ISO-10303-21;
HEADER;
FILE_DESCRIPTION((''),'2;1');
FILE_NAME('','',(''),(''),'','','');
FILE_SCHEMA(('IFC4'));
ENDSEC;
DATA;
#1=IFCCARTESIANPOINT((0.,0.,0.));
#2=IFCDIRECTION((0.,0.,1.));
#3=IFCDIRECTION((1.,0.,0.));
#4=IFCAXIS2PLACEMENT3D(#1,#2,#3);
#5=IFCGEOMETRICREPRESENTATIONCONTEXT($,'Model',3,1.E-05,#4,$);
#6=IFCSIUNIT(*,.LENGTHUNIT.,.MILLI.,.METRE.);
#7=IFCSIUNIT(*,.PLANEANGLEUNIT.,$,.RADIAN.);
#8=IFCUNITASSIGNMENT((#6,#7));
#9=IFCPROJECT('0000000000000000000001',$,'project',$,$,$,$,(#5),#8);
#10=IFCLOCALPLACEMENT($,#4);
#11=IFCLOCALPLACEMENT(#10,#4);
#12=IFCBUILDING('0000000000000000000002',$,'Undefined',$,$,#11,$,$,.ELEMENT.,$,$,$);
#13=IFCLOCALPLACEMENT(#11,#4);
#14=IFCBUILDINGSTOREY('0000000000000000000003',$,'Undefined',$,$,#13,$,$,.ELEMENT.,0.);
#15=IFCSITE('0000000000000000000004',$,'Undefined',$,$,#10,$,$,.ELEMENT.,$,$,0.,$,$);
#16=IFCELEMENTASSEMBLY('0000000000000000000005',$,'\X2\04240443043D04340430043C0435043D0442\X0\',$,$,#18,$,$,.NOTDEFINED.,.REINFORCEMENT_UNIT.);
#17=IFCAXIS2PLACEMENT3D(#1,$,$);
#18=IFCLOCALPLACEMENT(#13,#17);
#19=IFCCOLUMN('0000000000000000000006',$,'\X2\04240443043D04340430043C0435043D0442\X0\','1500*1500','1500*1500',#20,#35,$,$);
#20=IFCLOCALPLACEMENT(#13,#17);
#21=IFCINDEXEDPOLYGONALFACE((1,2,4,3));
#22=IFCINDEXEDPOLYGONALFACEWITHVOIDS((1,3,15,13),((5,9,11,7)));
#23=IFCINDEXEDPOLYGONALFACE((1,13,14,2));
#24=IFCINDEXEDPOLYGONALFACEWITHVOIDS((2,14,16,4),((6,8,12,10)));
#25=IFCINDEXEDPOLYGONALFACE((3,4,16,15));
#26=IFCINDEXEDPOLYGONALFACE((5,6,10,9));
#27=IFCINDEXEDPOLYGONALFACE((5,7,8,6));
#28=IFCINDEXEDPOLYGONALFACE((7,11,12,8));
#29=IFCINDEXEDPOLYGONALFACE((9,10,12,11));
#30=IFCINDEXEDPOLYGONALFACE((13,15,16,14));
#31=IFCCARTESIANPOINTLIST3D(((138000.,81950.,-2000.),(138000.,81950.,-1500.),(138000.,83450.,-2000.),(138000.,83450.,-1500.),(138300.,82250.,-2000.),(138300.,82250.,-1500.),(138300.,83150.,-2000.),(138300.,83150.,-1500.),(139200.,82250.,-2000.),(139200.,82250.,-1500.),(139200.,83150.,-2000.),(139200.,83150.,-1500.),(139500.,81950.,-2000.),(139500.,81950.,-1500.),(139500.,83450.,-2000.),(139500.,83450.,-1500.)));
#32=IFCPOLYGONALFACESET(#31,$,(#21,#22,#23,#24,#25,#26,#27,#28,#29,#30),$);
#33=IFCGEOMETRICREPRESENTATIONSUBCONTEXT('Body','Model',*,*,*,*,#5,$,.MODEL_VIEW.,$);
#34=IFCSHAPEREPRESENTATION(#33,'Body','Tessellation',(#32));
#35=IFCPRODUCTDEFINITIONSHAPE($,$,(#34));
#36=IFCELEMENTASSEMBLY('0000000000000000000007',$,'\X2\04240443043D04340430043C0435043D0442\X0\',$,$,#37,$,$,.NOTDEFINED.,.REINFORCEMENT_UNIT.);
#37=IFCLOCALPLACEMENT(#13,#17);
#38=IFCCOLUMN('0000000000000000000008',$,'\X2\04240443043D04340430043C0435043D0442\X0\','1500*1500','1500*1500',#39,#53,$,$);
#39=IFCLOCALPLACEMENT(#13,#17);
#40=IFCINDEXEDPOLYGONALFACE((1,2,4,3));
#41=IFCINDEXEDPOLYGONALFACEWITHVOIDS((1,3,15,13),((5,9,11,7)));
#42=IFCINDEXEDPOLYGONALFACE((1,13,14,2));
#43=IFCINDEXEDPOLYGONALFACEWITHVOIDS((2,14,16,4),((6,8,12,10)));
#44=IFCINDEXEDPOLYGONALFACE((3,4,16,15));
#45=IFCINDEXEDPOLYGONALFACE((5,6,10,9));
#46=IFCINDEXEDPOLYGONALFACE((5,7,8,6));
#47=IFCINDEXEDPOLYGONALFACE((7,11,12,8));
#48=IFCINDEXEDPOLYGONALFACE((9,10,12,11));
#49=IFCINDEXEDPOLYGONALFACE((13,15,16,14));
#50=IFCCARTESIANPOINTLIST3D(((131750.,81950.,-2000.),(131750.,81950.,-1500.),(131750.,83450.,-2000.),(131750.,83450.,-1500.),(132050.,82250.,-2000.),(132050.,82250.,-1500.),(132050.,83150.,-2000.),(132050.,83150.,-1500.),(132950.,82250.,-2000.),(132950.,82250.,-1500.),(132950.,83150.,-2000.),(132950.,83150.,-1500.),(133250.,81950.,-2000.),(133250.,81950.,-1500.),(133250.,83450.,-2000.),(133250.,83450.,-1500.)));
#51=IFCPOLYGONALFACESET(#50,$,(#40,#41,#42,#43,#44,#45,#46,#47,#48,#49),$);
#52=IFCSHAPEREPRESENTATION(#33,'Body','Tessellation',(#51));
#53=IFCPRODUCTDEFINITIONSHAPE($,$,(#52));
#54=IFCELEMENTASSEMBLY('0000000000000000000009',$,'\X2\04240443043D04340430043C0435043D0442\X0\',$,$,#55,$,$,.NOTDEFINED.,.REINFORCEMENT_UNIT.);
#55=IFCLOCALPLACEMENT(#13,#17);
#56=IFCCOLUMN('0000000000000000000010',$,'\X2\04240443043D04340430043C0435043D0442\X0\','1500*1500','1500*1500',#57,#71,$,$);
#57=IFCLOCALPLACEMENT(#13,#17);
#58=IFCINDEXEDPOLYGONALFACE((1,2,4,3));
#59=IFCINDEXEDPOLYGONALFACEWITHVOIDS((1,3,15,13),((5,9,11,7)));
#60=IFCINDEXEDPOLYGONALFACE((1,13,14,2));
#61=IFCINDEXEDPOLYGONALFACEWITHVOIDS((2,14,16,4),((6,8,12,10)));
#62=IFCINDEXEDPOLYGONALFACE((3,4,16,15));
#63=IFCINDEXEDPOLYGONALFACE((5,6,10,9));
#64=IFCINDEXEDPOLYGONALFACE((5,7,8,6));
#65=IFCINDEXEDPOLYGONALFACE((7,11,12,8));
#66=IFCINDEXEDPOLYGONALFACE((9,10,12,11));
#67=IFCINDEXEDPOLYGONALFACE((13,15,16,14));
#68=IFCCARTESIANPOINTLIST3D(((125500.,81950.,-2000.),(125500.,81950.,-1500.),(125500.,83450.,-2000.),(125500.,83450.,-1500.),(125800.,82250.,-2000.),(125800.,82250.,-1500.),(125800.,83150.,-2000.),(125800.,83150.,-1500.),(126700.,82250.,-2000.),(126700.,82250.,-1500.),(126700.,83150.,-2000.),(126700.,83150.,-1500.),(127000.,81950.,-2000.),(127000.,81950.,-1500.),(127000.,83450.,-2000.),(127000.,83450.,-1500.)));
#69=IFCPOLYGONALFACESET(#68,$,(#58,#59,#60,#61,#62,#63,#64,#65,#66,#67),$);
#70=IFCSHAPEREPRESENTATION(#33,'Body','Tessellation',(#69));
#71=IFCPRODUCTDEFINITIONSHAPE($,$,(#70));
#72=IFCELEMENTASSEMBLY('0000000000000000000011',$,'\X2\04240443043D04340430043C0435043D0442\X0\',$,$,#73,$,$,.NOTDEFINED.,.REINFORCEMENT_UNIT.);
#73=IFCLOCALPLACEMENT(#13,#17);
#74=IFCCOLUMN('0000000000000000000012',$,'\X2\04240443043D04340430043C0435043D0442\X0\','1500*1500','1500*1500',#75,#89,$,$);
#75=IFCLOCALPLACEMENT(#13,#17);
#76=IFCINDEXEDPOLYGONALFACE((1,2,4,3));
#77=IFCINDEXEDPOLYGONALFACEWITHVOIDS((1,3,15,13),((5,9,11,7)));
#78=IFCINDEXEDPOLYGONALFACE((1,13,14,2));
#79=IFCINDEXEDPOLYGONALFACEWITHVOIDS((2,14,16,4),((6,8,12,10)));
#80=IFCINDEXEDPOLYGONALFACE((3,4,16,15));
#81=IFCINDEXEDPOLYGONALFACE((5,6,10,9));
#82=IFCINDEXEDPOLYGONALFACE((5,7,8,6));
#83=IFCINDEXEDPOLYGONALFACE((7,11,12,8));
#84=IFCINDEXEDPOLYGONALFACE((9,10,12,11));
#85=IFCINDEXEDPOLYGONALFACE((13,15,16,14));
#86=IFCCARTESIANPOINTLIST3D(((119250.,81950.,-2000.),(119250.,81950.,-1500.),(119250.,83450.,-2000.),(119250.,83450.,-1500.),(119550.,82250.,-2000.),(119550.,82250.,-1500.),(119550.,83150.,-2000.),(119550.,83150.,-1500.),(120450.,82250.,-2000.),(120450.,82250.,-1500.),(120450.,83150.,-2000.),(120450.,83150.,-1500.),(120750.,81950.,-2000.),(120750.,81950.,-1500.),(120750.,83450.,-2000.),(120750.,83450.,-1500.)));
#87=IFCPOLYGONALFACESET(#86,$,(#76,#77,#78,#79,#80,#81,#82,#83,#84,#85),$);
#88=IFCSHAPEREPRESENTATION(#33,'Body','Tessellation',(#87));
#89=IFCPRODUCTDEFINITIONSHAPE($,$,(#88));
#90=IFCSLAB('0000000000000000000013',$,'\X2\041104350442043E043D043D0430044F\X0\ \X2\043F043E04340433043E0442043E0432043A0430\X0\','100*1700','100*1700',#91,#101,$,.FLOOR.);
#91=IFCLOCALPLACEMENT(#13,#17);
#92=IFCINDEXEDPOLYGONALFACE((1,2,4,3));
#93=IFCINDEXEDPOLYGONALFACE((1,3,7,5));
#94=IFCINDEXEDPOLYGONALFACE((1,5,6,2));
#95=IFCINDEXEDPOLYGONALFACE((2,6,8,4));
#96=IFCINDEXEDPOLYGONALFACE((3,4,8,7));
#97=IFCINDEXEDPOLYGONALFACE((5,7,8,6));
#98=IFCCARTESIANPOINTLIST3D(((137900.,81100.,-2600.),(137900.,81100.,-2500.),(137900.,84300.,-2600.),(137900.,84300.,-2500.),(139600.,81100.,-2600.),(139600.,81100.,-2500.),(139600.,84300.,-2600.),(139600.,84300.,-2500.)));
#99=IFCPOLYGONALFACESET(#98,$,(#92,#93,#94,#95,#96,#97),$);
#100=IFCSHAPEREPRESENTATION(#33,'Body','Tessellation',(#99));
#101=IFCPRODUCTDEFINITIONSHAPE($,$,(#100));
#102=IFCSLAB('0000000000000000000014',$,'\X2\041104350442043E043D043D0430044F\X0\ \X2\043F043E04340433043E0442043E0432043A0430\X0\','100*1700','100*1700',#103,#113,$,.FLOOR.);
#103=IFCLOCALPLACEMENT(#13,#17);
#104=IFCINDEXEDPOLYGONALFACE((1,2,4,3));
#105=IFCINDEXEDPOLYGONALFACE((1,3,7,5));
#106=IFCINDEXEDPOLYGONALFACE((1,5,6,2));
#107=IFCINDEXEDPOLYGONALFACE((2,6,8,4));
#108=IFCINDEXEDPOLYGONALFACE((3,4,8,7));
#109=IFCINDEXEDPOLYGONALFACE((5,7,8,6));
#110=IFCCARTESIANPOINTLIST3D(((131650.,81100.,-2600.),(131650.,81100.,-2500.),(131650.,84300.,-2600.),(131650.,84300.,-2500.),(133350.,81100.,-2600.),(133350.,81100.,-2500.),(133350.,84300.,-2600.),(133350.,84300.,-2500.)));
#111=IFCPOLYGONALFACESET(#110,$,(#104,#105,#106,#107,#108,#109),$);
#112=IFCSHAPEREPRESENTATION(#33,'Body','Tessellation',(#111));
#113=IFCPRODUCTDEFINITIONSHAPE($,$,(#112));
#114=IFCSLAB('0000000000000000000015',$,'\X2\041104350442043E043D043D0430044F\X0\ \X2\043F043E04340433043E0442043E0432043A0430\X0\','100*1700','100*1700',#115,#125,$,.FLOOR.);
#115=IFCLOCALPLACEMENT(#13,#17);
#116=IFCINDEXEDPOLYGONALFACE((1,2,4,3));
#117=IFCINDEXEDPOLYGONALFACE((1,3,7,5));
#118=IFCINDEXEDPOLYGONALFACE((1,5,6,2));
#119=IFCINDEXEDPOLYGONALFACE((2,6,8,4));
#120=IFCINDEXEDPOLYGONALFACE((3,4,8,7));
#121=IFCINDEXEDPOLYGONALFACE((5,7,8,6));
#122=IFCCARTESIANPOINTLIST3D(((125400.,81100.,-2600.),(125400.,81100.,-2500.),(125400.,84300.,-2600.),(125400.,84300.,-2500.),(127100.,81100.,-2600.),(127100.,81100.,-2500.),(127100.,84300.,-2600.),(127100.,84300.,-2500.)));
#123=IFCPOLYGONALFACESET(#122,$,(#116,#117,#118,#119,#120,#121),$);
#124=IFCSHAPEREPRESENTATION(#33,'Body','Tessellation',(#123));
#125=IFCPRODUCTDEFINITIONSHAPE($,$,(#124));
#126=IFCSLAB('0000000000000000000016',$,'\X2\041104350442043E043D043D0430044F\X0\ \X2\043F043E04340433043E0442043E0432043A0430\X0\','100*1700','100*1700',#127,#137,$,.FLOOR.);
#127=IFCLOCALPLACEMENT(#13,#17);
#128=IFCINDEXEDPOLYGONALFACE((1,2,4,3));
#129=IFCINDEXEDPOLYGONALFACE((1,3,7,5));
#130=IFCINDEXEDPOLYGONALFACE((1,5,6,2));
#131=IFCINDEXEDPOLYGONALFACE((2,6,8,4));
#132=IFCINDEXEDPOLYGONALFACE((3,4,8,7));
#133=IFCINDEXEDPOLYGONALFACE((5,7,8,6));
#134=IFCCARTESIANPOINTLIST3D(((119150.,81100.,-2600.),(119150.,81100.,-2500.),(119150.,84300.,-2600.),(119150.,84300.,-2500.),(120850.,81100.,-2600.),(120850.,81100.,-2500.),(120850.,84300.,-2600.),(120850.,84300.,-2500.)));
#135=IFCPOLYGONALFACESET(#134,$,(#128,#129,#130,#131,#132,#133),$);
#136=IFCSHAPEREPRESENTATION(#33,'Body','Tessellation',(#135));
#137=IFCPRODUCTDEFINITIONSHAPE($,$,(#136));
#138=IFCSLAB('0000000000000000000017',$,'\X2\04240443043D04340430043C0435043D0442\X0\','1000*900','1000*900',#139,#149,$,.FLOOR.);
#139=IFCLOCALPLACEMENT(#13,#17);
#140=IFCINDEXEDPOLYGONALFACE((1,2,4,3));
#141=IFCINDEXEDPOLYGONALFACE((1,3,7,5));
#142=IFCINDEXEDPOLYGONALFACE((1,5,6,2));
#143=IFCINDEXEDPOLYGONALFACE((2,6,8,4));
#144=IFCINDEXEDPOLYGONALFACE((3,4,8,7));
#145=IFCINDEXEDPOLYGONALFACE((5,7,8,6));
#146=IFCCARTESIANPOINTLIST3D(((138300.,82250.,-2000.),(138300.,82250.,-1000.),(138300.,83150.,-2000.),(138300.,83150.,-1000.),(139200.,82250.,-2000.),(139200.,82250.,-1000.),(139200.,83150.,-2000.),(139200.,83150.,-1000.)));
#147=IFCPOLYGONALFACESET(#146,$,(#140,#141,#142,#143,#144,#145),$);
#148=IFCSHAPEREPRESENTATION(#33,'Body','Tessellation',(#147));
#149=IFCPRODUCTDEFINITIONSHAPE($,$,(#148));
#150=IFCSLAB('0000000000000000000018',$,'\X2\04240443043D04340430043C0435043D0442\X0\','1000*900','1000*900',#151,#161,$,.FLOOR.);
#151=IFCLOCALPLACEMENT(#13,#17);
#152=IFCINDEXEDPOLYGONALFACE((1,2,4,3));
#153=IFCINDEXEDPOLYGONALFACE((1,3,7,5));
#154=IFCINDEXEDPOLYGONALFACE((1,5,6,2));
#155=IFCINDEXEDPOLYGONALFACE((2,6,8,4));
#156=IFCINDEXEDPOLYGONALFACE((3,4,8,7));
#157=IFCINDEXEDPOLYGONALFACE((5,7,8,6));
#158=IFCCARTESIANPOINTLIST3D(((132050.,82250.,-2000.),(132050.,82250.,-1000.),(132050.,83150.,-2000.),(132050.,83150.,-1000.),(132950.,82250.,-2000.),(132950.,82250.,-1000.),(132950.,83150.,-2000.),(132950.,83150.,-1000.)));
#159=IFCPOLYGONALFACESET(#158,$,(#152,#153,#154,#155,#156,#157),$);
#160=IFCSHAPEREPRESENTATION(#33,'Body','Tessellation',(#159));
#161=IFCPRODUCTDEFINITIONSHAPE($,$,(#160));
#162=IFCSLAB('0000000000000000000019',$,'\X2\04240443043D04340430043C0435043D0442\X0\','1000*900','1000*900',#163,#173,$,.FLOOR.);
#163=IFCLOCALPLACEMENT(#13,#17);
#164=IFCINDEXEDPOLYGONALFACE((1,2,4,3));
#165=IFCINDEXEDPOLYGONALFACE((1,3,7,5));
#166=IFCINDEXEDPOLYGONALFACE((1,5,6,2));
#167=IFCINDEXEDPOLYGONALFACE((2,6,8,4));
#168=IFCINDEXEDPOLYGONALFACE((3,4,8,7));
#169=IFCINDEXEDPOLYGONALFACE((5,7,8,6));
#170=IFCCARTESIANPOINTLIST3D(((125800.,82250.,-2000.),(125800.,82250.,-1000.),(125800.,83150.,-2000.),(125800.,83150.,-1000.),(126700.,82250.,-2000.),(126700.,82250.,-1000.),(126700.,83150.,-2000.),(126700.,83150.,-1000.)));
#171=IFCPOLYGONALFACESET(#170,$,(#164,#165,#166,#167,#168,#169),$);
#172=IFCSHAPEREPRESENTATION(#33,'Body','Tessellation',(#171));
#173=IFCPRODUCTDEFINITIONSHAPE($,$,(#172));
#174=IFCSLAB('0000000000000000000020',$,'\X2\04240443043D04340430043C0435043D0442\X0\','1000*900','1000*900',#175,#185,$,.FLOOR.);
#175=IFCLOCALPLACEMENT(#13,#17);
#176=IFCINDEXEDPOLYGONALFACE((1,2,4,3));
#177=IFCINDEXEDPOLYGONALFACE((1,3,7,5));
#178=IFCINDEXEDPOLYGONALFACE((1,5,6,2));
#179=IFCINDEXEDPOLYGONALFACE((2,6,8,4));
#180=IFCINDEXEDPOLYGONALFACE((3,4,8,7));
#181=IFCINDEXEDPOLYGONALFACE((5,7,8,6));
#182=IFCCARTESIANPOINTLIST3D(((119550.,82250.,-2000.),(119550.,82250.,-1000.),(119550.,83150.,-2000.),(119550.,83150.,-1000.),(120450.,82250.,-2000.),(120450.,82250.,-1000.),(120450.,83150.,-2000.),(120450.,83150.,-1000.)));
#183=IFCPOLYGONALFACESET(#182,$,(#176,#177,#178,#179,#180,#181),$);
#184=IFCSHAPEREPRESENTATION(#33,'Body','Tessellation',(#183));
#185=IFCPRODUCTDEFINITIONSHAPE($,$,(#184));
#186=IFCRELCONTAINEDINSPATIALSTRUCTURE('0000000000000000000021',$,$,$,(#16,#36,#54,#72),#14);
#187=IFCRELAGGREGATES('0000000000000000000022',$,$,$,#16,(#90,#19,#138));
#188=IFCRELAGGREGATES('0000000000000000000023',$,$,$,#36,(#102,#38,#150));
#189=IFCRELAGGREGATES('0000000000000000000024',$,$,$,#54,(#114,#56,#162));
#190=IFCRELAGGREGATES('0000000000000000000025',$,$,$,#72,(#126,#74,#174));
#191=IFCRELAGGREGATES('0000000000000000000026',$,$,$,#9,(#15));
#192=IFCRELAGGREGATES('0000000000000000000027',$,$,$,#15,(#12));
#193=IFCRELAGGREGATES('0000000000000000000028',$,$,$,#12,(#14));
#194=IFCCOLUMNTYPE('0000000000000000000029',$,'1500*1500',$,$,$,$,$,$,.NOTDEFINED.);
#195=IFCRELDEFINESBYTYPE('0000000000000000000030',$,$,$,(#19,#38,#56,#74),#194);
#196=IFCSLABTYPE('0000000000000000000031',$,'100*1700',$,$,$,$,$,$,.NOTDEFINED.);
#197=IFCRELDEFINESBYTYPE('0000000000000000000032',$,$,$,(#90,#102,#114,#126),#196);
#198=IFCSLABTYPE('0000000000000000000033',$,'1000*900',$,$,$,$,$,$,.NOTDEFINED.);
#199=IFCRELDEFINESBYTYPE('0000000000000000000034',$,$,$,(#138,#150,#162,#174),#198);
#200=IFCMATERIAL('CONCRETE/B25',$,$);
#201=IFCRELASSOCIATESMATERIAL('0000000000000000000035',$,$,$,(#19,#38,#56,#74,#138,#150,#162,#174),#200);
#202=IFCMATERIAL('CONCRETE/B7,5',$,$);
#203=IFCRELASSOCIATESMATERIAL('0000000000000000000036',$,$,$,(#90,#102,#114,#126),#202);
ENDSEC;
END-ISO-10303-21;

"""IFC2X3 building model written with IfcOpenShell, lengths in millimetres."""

from ifc_helpers import new_model, si_unit, frame, origin_with_axes, origin_2d_with_axis, place, context, subcontext, project, spatial, polyline, rectangle, outline, extrude, boolean, material, type_object, element, aggregate, save


model = new_model("IFC2X3")

# Units and contexts
model_context = context("Model", 3, precision=1e-05, world=origin_with_axes())
body_context = subcontext(model_context, "Body", "Model", "MODEL_VIEW")
ifc_project = project(units=[si_unit("LENGTHUNIT", "METRE", prefix="MILLI"), si_unit("PLANEANGLEUNIT", "RADIAN")], contexts=[model_context])

# Site, building, storey
site_placement = place(None, origin_with_axes())
site = spatial("IfcSite", under=ifc_project, at=site_placement, Name="Undefined", CompositionType="ELEMENT", RefElevation=0.0)
building_placement = place(site_placement, origin_with_axes())
building = spatial("IfcBuilding", under=site, at=building_placement, Name="Undefined", CompositionType="ELEMENT")
storey_placement = place(building_placement, origin_with_axes())
storey = spatial("IfcBuildingStorey", under=building, at=storey_placement, Name="Undefined", CompositionType="ELEMENT", Elevation=0.0)

# Element assemblies, columns
assembly_1_placement = place(storey_placement, origin_with_axes())
assembly_1 = element("IfcElementAssembly", 1, at=assembly_1_placement, inside=storey, Name="Фундамент", AssemblyPlace="NOTDEFINED", PredefinedType="REINFORCEMENT_UNIT")
ifc_material_1 = material(Name="CONCRETE/B25")
column_type = type_object("IfcColumnType", Name="1500*1500", PredefinedType="NOTDEFINED")
column_1_placement = place(assembly_1_placement, frame((138750.0, 82700.0, -2000.0), z_axis=(0.0, 0.0, 1.0), x_axis=(0.0, -1.0, 0.0)))
column_1 = element("IfcColumn", 2, at=column_1_placement, type_object=column_type, material=ifc_material_1, Name="Фундамент", Description="1500*1500", ObjectType="1500*1500", context=body_context, shape_type="CSG", body=[
    boolean("DIFFERENCE", extrude(rectangle(XDim=1500.0, YDim=1500.0, at=origin_2d_with_axis()), frame((0.0, 0.0, 500.0), z_axis=(0.0, 0.0, -1.0), x_axis=(0.0, 1.0, 0.0)), (0.0, 0.0, 1.0), 500.0), extrude(outline(polyline([(0.0, 0.0), (900.0, 0.0), (900.0, 900.0), (0.0, 900.0), (0.0, 0.0)])), frame((-450.0, -450.0, -100.0), z_axis=(0.0, 0.0, 1.0), x_axis=(1.0, 0.0, 0.0)), (0.0, 0.0, 1.0), 700.0)),
])
assembly_2_placement = place(storey_placement, origin_with_axes())
assembly_2 = element("IfcElementAssembly", 3, at=assembly_2_placement, inside=storey, Name="Фундамент", AssemblyPlace="NOTDEFINED", PredefinedType="REINFORCEMENT_UNIT")
column_2_placement = place(assembly_2_placement, frame((132500.0, 82700.0, -2000.0), z_axis=(0.0, 0.0, 1.0), x_axis=(0.0, -1.0, 0.0)))
column_2 = element("IfcColumn", 4, at=column_2_placement, type_object=column_type, material=ifc_material_1, Name="Фундамент", Description="1500*1500", ObjectType="1500*1500", context=body_context, shape_type="CSG", body=[
    boolean("DIFFERENCE", extrude(rectangle(XDim=1500.0, YDim=1500.0, at=origin_2d_with_axis()), frame((0.0, 0.0, 500.0), z_axis=(0.0, 0.0, -1.0), x_axis=(0.0, 1.0, 0.0)), (0.0, 0.0, 1.0), 500.0), extrude(outline(polyline([(0.0, 0.0), (900.0, 0.0), (900.0, 900.0), (0.0, 900.0), (0.0, 0.0)])), frame((-450.0, -450.0, -100.0), z_axis=(0.0, 0.0, 1.0), x_axis=(1.0, 0.0, 0.0)), (0.0, 0.0, 1.0), 700.0)),
])
assembly_3_placement = place(storey_placement, origin_with_axes())
assembly_3 = element("IfcElementAssembly", 5, at=assembly_3_placement, inside=storey, Name="Фундамент", AssemblyPlace="NOTDEFINED", PredefinedType="REINFORCEMENT_UNIT")
column_3_placement = place(assembly_3_placement, frame((126250.0, 82700.0, -2000.0), z_axis=(0.0, 0.0, 1.0), x_axis=(0.0, -1.0, 0.0)))
column_3 = element("IfcColumn", 6, at=column_3_placement, type_object=column_type, material=ifc_material_1, Name="Фундамент", Description="1500*1500", ObjectType="1500*1500", context=body_context, shape_type="CSG", body=[
    boolean("DIFFERENCE", extrude(rectangle(XDim=1500.0, YDim=1500.0, at=origin_2d_with_axis()), frame((0.0, 0.0, 500.0), z_axis=(0.0, 0.0, -1.0), x_axis=(0.0, 1.0, 0.0)), (0.0, 0.0, 1.0), 500.0), extrude(outline(polyline([(0.0, 0.0), (900.0, 0.0), (900.0, 900.0), (0.0, 900.0), (0.0, 0.0)])), frame((-450.0, -450.0, -100.0), z_axis=(0.0, 0.0, 1.0), x_axis=(1.0, 0.0, 0.0)), (0.0, 0.0, 1.0), 700.0)),
])
assembly_4_placement = place(storey_placement, origin_with_axes())
assembly_4 = element("IfcElementAssembly", 7, at=assembly_4_placement, inside=storey, Name="Фундамент", AssemblyPlace="NOTDEFINED", PredefinedType="REINFORCEMENT_UNIT")
column_4_placement = place(assembly_4_placement, frame((120000.0, 82700.0, -2000.0), z_axis=(0.0, 0.0, 1.0), x_axis=(0.0, -1.0, 0.0)))
column_4 = element("IfcColumn", 8, at=column_4_placement, type_object=column_type, material=ifc_material_1, Name="Фундамент", Description="1500*1500", ObjectType="1500*1500", context=body_context, shape_type="CSG", body=[
    boolean("DIFFERENCE", extrude(rectangle(XDim=1500.0, YDim=1500.0, at=origin_2d_with_axis()), frame((0.0, 0.0, 500.0), z_axis=(0.0, 0.0, -1.0), x_axis=(0.0, 1.0, 0.0)), (0.0, 0.0, 1.0), 500.0), extrude(outline(polyline([(0.0, 0.0), (900.0, 0.0), (900.0, 900.0), (0.0, 900.0), (0.0, 0.0)])), frame((-450.0, -450.0, -100.0), z_axis=(0.0, 0.0, 1.0), x_axis=(1.0, 0.0, 0.0)), (0.0, 0.0, 1.0), 700.0)),
])

# Slabs
ifc_material_2 = material(Name="CONCRETE/B7,5")
slab_type_1 = type_object("IfcSlabType", Name="100*1700", PredefinedType="NOTDEFINED")
slab_1_placement = place(assembly_1_placement, frame((137900.0, 84300.0, -2550.0), z_axis=(0.0, 0.0, 1.0), x_axis=(0.0, -1.0, 0.0)))
slab_1 = element("IfcSlab", 9, at=slab_1_placement, type_object=slab_type_1, material=ifc_material_2, Name="Бетонная подготовка", Description="100*1700", ObjectType="100*1700", PredefinedType="FLOOR", context=body_context, shape_type="SweptSolid", body=[
    extrude(outline(polyline([(0.0, 0.0), (3200.0, 0.0), (3200.0, 1700.0), (0.0, 1700.0), (0.0, 0.0)])), frame((0.0, 0.0, -50.0), z_axis=(0.0, 0.0, 1.0), x_axis=(1.0, 0.0, 0.0)), (0.0, 0.0, 1.0), 100.0),
])
slab_2_placement = place(assembly_2_placement, frame((131650.0, 84300.0, -2550.0), z_axis=(0.0, 0.0, 1.0), x_axis=(0.0, -1.0, 0.0)))
slab_2 = element("IfcSlab", 10, at=slab_2_placement, type_object=slab_type_1, material=ifc_material_2, Name="Бетонная подготовка", Description="100*1700", ObjectType="100*1700", PredefinedType="FLOOR", context=body_context, shape_type="SweptSolid", body=[
    extrude(outline(polyline([(0.0, 0.0), (3200.0, 0.0), (3200.0, 1700.0), (0.0, 1700.0), (0.0, 0.0)])), frame((0.0, 0.0, -50.0), z_axis=(0.0, 0.0, 1.0), x_axis=(1.0, 0.0, 0.0)), (0.0, 0.0, 1.0), 100.0),
])
slab_3_placement = place(assembly_3_placement, frame((125400.0, 84300.0, -2550.0), z_axis=(0.0, 0.0, 1.0), x_axis=(0.0, -1.0, 0.0)))
slab_3 = element("IfcSlab", 11, at=slab_3_placement, type_object=slab_type_1, material=ifc_material_2, Name="Бетонная подготовка", Description="100*1700", ObjectType="100*1700", PredefinedType="FLOOR", context=body_context, shape_type="SweptSolid", body=[
    extrude(outline(polyline([(0.0, 0.0), (3200.0, 0.0), (3200.0, 1700.0), (0.0, 1700.0), (0.0, 0.0)])), frame((0.0, 0.0, -50.0), z_axis=(0.0, 0.0, 1.0), x_axis=(1.0, 0.0, 0.0)), (0.0, 0.0, 1.0), 100.0),
])
slab_4_placement = place(assembly_4_placement, frame((119150.0, 84300.0, -2550.0), z_axis=(0.0, 0.0, 1.0), x_axis=(0.0, -1.0, 0.0)))
slab_4 = element("IfcSlab", 12, at=slab_4_placement, type_object=slab_type_1, material=ifc_material_2, Name="Бетонная подготовка", Description="100*1700", ObjectType="100*1700", PredefinedType="FLOOR", context=body_context, shape_type="SweptSolid", body=[
    extrude(outline(polyline([(0.0, 0.0), (3200.0, 0.0), (3200.0, 1700.0), (0.0, 1700.0), (0.0, 0.0)])), frame((0.0, 0.0, -50.0), z_axis=(0.0, 0.0, 1.0), x_axis=(1.0, 0.0, 0.0)), (0.0, 0.0, 1.0), 100.0),
])
slab_type_2 = type_object("IfcSlabType", Name="1000*900", PredefinedType="NOTDEFINED")
slab_5_placement = place(assembly_1_placement, frame((138300.0, 83150.0, -1500.0), z_axis=(0.0, 0.0, 1.0), x_axis=(0.0, -1.0, 0.0)))
slab_5 = element("IfcSlab", 13, at=slab_5_placement, type_object=slab_type_2, material=ifc_material_1, Name="Фундамент", Description="1000*900", ObjectType="1000*900", PredefinedType="FLOOR", context=body_context, shape_type="SweptSolid", body=[
    extrude(outline(polyline([(0.0, 0.0), (900.0, 0.0), (900.0, 900.0), (0.0, 900.0), (0.0, 0.0)])), frame((0.0, 0.0, -500.0), z_axis=(0.0, 0.0, 1.0), x_axis=(1.0, 0.0, 0.0)), (0.0, 0.0, 1.0), 1000.0),
])
slab_6_placement = place(assembly_2_placement, frame((132050.0, 83150.0, -1500.0), z_axis=(0.0, 0.0, 1.0), x_axis=(0.0, -1.0, 0.0)))
slab_6 = element("IfcSlab", 14, at=slab_6_placement, type_object=slab_type_2, material=ifc_material_1, Name="Фундамент", Description="1000*900", ObjectType="1000*900", PredefinedType="FLOOR", context=body_context, shape_type="SweptSolid", body=[
    extrude(outline(polyline([(0.0, 0.0), (900.0, 0.0), (900.0, 900.0), (0.0, 900.0), (0.0, 0.0)])), frame((0.0, 0.0, -500.0), z_axis=(0.0, 0.0, 1.0), x_axis=(1.0, 0.0, 0.0)), (0.0, 0.0, 1.0), 1000.0),
])
slab_7_placement = place(assembly_3_placement, frame((125800.0, 83150.0, -1500.0), z_axis=(0.0, 0.0, 1.0), x_axis=(0.0, -1.0, 0.0)))
slab_7 = element("IfcSlab", 15, at=slab_7_placement, type_object=slab_type_2, material=ifc_material_1, Name="Фундамент", Description="1000*900", ObjectType="1000*900", PredefinedType="FLOOR", context=body_context, shape_type="SweptSolid", body=[
    extrude(outline(polyline([(0.0, 0.0), (900.0, 0.0), (900.0, 900.0), (0.0, 900.0), (0.0, 0.0)])), frame((0.0, 0.0, -500.0), z_axis=(0.0, 0.0, 1.0), x_axis=(1.0, 0.0, 0.0)), (0.0, 0.0, 1.0), 1000.0),
])
slab_8_placement = place(assembly_4_placement, frame((119550.0, 83150.0, -1500.0), z_axis=(0.0, 0.0, 1.0), x_axis=(0.0, -1.0, 0.0)))
slab_8 = element("IfcSlab", 16, at=slab_8_placement, type_object=slab_type_2, material=ifc_material_1, Name="Фундамент", Description="1000*900", ObjectType="1000*900", PredefinedType="FLOOR", context=body_context, shape_type="SweptSolid", body=[
    extrude(outline(polyline([(0.0, 0.0), (900.0, 0.0), (900.0, 900.0), (0.0, 900.0), (0.0, 0.0)])), frame((0.0, 0.0, -500.0), z_axis=(0.0, 0.0, 1.0), x_axis=(1.0, 0.0, 0.0)), (0.0, 0.0, 1.0), 1000.0),
])
aggregate(assembly_1, [slab_1, column_1, slab_5])
aggregate(assembly_2, [slab_2, column_2, slab_6])
aggregate(assembly_3, [slab_3, column_3, slab_7])
aggregate(assembly_4, [slab_4, column_4, slab_8])

save(model, "model.ifc")
